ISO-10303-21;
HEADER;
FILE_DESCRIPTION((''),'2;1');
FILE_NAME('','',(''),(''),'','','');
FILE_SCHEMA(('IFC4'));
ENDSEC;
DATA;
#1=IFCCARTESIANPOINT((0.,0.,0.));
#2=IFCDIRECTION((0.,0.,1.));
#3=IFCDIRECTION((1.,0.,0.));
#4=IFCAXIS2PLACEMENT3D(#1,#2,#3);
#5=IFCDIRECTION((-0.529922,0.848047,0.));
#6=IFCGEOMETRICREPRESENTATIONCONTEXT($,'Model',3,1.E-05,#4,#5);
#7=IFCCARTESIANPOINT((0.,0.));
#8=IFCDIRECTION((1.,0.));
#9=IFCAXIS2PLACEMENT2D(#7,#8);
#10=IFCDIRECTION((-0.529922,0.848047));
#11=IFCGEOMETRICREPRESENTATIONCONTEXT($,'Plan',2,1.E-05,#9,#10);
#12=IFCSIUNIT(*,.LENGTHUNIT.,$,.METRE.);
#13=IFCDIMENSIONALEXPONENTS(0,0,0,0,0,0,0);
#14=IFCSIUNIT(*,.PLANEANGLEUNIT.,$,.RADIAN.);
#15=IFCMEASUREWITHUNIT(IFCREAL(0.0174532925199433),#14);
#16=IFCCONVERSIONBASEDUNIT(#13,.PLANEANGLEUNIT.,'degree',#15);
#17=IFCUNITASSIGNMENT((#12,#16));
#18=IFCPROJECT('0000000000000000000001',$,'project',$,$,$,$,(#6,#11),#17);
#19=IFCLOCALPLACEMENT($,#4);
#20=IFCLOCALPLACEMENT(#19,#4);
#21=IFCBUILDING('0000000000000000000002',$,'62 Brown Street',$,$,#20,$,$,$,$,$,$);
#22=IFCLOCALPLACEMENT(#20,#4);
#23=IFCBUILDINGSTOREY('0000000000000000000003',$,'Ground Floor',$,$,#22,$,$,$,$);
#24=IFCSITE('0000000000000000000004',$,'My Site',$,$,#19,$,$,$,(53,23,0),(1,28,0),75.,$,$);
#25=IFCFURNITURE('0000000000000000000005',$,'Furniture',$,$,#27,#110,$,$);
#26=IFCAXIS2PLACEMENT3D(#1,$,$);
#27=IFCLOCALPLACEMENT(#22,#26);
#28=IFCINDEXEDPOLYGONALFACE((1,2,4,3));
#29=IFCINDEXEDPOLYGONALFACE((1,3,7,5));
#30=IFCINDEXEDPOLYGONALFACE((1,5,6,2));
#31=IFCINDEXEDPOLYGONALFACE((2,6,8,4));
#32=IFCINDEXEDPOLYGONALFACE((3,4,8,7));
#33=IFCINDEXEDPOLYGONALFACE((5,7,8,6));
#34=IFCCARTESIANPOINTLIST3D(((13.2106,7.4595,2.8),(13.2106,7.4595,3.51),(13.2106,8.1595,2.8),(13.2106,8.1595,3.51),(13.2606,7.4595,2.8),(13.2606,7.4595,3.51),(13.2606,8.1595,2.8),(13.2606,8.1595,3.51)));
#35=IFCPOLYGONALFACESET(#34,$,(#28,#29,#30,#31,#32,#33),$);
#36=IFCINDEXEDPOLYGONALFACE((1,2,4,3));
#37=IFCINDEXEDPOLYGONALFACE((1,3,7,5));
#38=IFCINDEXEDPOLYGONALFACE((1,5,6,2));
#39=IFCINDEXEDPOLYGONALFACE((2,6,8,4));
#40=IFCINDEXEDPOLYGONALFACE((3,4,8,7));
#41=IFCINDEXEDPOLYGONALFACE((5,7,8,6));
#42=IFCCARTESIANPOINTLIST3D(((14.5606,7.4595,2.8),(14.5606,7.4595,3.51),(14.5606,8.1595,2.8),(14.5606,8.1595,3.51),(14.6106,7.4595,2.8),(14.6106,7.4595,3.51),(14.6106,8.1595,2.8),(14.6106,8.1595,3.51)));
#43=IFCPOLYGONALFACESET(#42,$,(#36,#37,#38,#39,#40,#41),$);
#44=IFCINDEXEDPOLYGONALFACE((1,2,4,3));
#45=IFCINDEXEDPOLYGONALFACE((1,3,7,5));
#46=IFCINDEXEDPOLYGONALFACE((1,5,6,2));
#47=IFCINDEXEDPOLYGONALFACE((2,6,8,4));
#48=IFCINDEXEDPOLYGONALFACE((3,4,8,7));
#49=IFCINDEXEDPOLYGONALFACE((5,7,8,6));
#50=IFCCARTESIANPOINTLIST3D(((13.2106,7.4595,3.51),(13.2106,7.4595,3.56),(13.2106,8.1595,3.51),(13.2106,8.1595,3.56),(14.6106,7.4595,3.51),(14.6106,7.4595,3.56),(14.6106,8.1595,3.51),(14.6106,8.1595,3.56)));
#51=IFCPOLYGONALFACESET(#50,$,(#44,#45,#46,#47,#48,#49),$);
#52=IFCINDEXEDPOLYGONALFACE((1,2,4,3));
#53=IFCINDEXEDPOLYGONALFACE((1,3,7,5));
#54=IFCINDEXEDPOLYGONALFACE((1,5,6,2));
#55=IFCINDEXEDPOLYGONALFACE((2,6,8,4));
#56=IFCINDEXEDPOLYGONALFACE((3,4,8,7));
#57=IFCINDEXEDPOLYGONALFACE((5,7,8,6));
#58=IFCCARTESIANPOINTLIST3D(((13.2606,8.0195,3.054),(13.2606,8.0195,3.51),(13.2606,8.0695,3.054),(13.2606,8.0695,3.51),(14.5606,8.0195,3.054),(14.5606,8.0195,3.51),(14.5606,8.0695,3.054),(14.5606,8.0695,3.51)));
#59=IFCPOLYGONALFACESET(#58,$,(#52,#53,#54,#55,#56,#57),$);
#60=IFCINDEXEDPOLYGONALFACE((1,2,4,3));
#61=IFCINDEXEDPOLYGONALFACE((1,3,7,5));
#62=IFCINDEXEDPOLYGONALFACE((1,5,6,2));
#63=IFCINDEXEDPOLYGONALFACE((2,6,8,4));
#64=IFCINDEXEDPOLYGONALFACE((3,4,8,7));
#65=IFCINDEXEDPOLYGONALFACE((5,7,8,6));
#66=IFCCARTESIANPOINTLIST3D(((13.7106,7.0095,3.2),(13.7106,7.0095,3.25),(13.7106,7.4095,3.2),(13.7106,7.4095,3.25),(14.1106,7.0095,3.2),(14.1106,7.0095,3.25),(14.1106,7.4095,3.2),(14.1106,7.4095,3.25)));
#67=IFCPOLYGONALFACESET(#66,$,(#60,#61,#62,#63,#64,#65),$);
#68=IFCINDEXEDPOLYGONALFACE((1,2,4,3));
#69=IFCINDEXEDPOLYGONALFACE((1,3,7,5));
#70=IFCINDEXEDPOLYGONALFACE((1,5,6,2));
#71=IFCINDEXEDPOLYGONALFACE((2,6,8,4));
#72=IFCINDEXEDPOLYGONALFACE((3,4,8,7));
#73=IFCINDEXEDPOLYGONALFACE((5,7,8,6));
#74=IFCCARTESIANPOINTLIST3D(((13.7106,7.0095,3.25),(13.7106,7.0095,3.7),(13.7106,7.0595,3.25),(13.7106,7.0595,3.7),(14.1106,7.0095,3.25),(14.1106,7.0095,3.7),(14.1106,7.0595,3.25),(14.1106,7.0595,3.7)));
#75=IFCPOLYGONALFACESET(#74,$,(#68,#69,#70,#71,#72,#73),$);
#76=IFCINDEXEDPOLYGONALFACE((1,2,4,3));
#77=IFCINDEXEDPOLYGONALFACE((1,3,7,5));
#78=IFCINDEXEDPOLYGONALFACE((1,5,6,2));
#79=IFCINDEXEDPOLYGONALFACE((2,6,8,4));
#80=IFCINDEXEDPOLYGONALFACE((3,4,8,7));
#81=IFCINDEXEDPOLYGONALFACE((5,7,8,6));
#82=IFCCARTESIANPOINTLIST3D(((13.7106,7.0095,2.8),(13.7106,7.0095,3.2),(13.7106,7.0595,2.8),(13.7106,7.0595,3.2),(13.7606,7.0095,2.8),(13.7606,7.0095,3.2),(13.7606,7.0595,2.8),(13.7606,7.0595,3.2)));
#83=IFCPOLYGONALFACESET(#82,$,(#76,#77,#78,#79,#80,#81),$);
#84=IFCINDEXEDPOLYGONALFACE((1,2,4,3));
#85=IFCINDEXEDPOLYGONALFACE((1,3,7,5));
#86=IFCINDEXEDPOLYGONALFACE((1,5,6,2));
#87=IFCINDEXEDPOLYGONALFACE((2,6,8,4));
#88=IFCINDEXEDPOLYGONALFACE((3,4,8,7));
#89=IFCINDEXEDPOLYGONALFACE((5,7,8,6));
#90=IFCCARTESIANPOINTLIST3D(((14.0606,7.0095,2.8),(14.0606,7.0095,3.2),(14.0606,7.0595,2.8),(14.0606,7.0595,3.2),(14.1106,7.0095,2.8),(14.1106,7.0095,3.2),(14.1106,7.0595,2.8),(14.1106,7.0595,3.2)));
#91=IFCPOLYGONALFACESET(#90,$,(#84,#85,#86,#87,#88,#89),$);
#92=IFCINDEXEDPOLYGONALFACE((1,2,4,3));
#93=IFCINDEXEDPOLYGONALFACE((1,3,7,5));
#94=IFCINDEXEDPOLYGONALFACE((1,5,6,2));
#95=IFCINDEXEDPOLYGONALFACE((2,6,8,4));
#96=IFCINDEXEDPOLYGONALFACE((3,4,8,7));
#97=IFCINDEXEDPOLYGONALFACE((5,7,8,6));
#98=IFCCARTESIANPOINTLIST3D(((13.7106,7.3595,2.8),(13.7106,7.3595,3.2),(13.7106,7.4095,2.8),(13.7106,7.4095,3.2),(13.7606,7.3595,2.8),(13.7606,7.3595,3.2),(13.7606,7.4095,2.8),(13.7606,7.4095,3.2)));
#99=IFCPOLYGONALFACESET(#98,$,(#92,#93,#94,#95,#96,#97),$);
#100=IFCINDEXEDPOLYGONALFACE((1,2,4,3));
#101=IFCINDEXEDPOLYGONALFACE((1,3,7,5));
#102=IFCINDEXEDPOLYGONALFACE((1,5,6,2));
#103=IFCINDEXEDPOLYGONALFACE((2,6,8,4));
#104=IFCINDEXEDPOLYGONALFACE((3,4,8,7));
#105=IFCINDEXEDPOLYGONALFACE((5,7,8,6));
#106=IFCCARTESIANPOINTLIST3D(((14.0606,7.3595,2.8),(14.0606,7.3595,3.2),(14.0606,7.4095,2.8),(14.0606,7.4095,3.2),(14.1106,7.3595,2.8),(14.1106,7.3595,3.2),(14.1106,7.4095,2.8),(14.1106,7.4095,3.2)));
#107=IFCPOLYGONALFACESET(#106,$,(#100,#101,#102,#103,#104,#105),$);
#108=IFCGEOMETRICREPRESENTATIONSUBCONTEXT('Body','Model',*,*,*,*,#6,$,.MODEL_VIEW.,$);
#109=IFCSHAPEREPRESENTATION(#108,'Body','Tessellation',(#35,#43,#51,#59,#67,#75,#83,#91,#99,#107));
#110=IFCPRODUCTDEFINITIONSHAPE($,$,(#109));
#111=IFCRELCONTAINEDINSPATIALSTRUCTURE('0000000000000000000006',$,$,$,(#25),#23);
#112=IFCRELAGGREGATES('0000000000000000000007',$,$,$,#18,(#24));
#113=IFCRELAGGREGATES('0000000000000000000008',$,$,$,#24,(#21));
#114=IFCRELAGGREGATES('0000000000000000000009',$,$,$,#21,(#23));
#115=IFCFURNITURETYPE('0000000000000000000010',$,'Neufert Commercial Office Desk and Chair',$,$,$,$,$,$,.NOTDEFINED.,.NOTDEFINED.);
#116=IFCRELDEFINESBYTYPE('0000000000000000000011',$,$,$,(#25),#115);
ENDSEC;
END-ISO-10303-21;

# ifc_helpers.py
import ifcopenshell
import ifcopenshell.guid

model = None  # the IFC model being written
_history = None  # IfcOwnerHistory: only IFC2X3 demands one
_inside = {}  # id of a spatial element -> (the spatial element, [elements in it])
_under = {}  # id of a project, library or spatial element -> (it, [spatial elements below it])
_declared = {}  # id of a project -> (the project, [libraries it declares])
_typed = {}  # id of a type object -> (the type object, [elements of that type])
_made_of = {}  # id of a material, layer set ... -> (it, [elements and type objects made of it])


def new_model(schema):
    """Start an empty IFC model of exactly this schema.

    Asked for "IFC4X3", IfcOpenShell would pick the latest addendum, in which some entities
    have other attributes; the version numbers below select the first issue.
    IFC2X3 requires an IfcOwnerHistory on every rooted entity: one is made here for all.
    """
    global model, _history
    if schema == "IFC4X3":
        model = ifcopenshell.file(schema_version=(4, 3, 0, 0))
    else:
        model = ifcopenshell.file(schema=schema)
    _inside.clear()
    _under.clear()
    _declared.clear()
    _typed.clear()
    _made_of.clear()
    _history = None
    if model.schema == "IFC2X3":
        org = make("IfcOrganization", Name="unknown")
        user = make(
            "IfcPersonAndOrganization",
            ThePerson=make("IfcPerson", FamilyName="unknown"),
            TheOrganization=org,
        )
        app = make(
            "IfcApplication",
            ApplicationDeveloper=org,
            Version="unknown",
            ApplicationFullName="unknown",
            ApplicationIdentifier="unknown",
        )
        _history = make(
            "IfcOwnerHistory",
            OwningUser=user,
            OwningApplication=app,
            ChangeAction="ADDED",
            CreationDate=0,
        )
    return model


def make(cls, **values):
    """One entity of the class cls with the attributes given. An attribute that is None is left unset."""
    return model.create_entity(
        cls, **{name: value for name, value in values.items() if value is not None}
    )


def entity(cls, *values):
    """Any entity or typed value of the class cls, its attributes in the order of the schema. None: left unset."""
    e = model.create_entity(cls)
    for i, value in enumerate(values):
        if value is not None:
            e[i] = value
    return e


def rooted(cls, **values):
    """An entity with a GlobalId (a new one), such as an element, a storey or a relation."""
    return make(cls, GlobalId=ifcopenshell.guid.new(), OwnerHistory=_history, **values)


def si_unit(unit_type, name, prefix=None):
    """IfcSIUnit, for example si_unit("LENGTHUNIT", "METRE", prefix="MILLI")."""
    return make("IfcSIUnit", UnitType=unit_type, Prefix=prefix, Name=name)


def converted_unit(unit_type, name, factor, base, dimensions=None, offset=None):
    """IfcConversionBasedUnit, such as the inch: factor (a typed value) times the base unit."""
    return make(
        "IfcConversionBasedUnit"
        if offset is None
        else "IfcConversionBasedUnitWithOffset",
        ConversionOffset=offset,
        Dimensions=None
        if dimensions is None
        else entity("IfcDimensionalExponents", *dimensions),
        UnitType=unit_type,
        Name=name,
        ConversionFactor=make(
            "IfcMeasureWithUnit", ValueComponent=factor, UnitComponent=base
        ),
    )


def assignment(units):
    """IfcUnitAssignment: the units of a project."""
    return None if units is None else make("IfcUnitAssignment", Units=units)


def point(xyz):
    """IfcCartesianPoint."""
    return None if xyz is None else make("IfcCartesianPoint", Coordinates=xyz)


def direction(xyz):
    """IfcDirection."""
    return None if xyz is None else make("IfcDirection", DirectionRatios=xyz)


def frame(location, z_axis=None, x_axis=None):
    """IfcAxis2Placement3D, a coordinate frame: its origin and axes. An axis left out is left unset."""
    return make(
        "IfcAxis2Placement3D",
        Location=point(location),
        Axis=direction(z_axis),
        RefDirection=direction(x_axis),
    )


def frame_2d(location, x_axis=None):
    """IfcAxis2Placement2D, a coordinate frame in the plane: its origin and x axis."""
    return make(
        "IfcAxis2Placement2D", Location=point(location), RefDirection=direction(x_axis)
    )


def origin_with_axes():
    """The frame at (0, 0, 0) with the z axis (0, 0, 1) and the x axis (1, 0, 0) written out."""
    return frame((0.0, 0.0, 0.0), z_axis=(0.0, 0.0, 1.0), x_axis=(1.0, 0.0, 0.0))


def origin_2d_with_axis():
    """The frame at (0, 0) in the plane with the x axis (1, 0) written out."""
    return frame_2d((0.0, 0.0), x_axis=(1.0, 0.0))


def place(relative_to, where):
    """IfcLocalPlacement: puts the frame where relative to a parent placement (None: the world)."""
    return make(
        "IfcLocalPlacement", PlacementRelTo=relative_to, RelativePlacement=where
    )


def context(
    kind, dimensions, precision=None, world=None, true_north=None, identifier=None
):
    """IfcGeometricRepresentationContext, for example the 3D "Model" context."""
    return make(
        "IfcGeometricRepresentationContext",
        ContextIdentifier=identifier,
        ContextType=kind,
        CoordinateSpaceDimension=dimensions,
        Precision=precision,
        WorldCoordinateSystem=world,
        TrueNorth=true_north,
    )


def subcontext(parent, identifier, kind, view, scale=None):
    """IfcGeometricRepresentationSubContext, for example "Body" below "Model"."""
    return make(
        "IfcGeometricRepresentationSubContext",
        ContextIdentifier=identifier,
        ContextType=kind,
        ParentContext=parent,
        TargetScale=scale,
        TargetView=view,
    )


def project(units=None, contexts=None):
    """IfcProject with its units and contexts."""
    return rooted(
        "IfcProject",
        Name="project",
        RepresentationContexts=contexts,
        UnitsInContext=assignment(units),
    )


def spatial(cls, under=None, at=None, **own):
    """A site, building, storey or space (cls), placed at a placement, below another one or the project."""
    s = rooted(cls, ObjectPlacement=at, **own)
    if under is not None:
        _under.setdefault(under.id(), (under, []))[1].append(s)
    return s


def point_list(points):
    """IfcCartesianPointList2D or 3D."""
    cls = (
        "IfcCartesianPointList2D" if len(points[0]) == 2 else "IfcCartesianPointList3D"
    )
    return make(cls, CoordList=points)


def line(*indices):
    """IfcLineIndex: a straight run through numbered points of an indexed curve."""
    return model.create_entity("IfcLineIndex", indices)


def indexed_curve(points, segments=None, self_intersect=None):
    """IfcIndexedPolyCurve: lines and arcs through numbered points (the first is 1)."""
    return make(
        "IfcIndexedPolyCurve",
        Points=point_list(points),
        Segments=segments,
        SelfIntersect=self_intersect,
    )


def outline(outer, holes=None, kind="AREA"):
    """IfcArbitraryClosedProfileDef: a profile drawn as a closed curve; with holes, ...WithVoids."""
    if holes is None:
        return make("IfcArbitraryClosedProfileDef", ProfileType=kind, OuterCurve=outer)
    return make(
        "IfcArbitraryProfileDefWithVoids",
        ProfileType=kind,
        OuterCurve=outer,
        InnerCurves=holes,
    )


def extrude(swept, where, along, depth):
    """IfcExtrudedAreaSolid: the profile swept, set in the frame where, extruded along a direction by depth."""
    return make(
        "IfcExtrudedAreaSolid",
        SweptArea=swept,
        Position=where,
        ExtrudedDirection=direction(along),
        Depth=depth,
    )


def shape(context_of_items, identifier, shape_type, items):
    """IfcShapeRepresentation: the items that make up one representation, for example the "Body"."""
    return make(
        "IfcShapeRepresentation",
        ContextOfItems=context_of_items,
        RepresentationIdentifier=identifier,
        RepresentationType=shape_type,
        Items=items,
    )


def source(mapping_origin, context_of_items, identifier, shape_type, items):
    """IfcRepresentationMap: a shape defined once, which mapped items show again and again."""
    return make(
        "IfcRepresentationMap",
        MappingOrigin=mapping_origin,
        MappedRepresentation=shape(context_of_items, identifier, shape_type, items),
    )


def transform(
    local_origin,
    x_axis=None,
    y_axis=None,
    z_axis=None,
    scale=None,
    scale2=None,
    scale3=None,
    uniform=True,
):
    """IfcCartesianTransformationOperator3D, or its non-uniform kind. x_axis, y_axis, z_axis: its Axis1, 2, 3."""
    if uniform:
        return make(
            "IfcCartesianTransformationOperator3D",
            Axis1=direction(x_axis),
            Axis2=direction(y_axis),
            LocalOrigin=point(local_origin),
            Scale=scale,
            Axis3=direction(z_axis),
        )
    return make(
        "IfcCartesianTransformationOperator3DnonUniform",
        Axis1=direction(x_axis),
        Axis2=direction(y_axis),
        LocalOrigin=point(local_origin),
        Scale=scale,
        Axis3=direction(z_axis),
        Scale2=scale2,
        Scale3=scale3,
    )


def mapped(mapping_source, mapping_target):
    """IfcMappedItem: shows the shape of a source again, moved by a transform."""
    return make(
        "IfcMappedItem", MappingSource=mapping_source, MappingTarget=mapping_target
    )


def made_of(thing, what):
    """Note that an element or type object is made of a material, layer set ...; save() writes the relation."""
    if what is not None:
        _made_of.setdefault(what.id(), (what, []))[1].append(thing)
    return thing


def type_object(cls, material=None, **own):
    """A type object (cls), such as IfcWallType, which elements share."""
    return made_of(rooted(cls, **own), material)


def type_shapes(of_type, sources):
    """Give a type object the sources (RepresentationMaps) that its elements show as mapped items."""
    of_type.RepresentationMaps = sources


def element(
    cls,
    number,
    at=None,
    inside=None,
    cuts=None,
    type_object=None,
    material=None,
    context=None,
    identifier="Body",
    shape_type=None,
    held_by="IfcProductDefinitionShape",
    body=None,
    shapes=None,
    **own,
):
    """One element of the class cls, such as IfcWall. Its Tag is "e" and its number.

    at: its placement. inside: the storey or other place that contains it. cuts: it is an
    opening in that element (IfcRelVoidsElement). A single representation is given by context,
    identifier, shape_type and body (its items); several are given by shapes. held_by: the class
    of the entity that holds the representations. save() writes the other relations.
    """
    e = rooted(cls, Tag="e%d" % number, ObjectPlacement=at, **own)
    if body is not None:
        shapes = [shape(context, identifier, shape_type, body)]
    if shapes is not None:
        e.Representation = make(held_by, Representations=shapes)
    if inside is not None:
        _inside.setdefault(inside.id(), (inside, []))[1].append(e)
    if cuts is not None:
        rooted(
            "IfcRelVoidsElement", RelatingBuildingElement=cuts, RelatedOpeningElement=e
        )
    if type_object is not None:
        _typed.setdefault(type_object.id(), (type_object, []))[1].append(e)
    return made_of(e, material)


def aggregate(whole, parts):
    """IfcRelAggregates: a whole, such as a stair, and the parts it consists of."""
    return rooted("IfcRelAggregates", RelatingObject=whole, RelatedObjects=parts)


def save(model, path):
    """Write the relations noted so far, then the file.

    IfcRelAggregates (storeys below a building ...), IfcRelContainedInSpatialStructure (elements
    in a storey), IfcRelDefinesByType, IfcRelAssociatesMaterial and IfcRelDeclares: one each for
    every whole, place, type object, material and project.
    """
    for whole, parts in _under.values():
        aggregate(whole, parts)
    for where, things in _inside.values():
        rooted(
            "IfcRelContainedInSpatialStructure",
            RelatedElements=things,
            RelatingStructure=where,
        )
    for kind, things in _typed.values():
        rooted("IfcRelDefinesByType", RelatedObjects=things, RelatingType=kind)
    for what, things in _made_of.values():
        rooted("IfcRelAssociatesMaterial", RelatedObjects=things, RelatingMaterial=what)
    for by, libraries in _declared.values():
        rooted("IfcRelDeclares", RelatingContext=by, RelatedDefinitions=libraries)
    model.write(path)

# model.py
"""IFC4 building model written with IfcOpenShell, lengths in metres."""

from ifc_helpers import new_model, entity, si_unit, converted_unit, direction, frame, origin_with_axes, origin_2d_with_axis, place, context, subcontext, project, spatial, line, indexed_curve, outline, extrude, shape, source, transform, mapped, type_object, type_shapes, element, save


model = new_model("IFC4")

# Units and contexts
model_context = context("Model", 3, precision=1e-05, world=origin_with_axes(), true_north=direction((-0.529922, 0.848047, 0.0)))
plan_context = context("Plan", 2, precision=1e-05, world=origin_2d_with_axis(), true_north=direction((-0.529922, 0.848047)))
body_context_1 = subcontext(model_context, "Body", "Model", "MODEL_VIEW")
body_context_2 = subcontext(plan_context, "Body", "Plan", "PLAN_VIEW")
ifc_project = project(units=[si_unit("LENGTHUNIT", "METRE"), converted_unit("PLANEANGLEUNIT", "degree", entity("IfcReal", 0.0174532925199433), si_unit("PLANEANGLEUNIT", "RADIAN"), dimensions=[0, 0, 0, 0, 0, 0, 0])], contexts=[model_context, plan_context])

# Site, building, storey
site_placement = place(None, origin_with_axes())
site = spatial("IfcSite", under=ifc_project, at=site_placement, Name="My Site", RefLatitude=(53, 23, 0), RefLongitude=(1, 28, 0), RefElevation=75.0)
building_placement = place(site_placement, origin_with_axes())
building = spatial("IfcBuilding", under=site, at=building_placement, Name="62 Brown Street")
storey_placement = place(building_placement, origin_with_axes())
storey = spatial("IfcBuildingStorey", under=building, at=storey_placement, Name="Ground Floor")

# Furniture
furniture_type_1 = type_object("IfcFurnitureType", Name="Neufert Commercial Office Desk and Chair", AssemblyPlace="NOTDEFINED", PredefinedType="NOTDEFINED")
shared_shape_1 = source(origin_with_axes(), body_context_1, "Body", "SweptSolid", [
    extrude(outline(indexed_curve([(0.0, 0.0), (0.05, 0.0), (0.05, 0.7), (0.0, 0.7)], segments=[line(1, 2, 3, 4, 1)])), frame((0.0, 0.45, 0.0), z_axis=(0.0, 0.0, 1.0), x_axis=(1.0, 0.0, 0.0)), (0.0, 0.0, 1.0), 0.71),
    extrude(outline(indexed_curve([(0.0, 0.0), (0.05, 0.0), (0.05, 0.7), (0.0, 0.7)], segments=[line(1, 2, 3, 4, 1)])), frame((1.35, 0.45, 0.0), z_axis=(0.0, 0.0, 1.0), x_axis=(1.0, 0.0, 0.0)), (0.0, 0.0, 1.0), 0.71),
    extrude(outline(indexed_curve([(0.0, 0.0), (1.4, 0.0), (1.4, 0.7), (0.0, 0.7)], segments=[line(1, 2, 3, 4, 1)])), frame((0.0, 0.45, 0.71), z_axis=(0.0, 0.0, 1.0), x_axis=(1.0, 0.0, 0.0)), (0.0, 0.0, 1.0), 0.05),
    extrude(outline(indexed_curve([(0.05, 0.56), (1.35, 0.56), (1.35, 0.61), (0.05, 0.61)], segments=[line(1, 2, 3, 4, 1)])), frame((0.0, 0.45, 0.254), z_axis=(0.0, 0.0, 1.0), x_axis=(1.0, 0.0, 0.0)), (0.0, 0.0, 1.0), 0.456),
    extrude(outline(indexed_curve([(-0.2, 0.0), (0.2, 0.0), (0.2, 0.4), (-0.2, 0.4)], segments=[line(1, 2, 3, 4, 1)])), frame((0.7, 0.0, 0.45), z_axis=(0.0, 0.0, 1.0), x_axis=(1.0, 0.0, 0.0)), (0.0, 0.0, -1.0), 0.05),
    extrude(outline(indexed_curve([(-0.2, 0.0), (0.2, 0.0), (0.2, 0.05), (-0.2, 0.05)], segments=[line(1, 2, 3, 4, 1)])), frame((0.7, 0.0, 0.9), z_axis=(0.0, 0.0, 1.0), x_axis=(1.0, 0.0, 0.0)), (0.0, 0.0, -1.0), 0.45),
    extrude(outline(indexed_curve([(-0.2, 0.0), (-0.15, 0.0), (-0.15, 0.05), (-0.2, 0.05)], segments=[line(1, 2, 3, 4, 1)])), frame((0.7, 0.0, 0.0), z_axis=(0.0, 0.0, 1.0), x_axis=(1.0, 0.0, 0.0)), (0.0, 0.0, 1.0), 0.4),
    extrude(outline(indexed_curve([(0.2, 0.0), (0.15, 0.0), (0.15, 0.05), (0.2, 0.05)], segments=[line(1, 2, 3, 4, 1)])), frame((0.7, 0.0, 0.0), z_axis=(0.0, 0.0, 1.0), x_axis=(1.0, 0.0, 0.0)), (0.0, 0.0, 1.0), 0.4),
    extrude(outline(indexed_curve([(-0.2, 0.4), (-0.15, 0.4), (-0.15, 0.35), (-0.2, 0.35)], segments=[line(1, 2, 3, 4, 1)])), frame((0.7, 0.0, 0.0), z_axis=(0.0, 0.0, 1.0), x_axis=(1.0, 0.0, 0.0)), (0.0, 0.0, 1.0), 0.4),
    extrude(outline(indexed_curve([(0.2, 0.4), (0.15, 0.4), (0.15, 0.35), (0.2, 0.35)], segments=[line(1, 2, 3, 4, 1)])), frame((0.7, 0.0, 0.0), z_axis=(0.0, 0.0, 1.0), x_axis=(1.0, 0.0, 0.0)), (0.0, 0.0, 1.0), 0.4),
])
shared_shape_2 = source(origin_with_axes(), body_context_2, "Body", "Curve2D", [
    entity("IfcIndexedPolyCurve", entity("IfcCartesianPointList2D", [[0.0, 0.45], [1.4, 0.45], [1.4, 1.15], [0.0, 1.15]]), [entity("IfcLineIndex", [1, 2, 3, 4, 1])]),
    entity("IfcIndexedPolyCurve", entity("IfcCartesianPointList2D", [[0.5, 0.4], [0.9, 0.4]])),
    entity("IfcIndexedPolyCurve", entity("IfcCartesianPointList2D", [[0.5, 0.4], [0.5, 0.2], [0.5586, 0.0586], [0.7, 0.0], [0.8414, 0.0586], [0.9, 0.2], [0.9, 0.4]]), [entity("IfcLineIndex", [1, 2]), entity("IfcArcIndex", [2, 3, 4]), entity("IfcArcIndex", [4, 5, 6]), entity("IfcLineIndex", [6, 7])]),
    entity("IfcIndexedPolyCurve", entity("IfcCartesianPointList2D", [[0.54, 0.4], [0.54, 0.2], [0.5869, 0.0869], [0.7, 0.04], [0.8131, 0.0869], [0.86, 0.2], [0.86, 0.4]]), [entity("IfcLineIndex", [1, 2]), entity("IfcArcIndex", [2, 3, 4]), entity("IfcArcIndex", [4, 5, 6]), entity("IfcLineIndex", [6, 7])]),
])
type_shapes(furniture_type_1, [shared_shape_1, shared_shape_2])
furniture_1_placement = place(storey_placement, frame((13.2106, 7.0095, 2.8), z_axis=(0.0, 0.0, 1.0), x_axis=(1.0, 0.0, 0.0)))
element("IfcFurniture", 1, at=furniture_1_placement, inside=storey, type_object=furniture_type_1, Name="Furniture", shapes=[
    shape(body_context_1, "Body", "MappedRepresentation", [mapped(shared_shape_1, transform((0.0, 0.0, 0.0), x_axis=(1.0, 0.0, 0.0), y_axis=(0.0, 1.0, 0.0), z_axis=(0.0, 0.0, 1.0), scale=1.0))]),
    shape(body_context_2, "Body", "MappedRepresentation", [mapped(shared_shape_2, transform((0.0, 0.0, 0.0), x_axis=(1.0, 0.0, 0.0), y_axis=(0.0, 1.0, 0.0), z_axis=(0.0, 0.0, 1.0), scale=1.0))]),
])

save(model, "model.ifc")
